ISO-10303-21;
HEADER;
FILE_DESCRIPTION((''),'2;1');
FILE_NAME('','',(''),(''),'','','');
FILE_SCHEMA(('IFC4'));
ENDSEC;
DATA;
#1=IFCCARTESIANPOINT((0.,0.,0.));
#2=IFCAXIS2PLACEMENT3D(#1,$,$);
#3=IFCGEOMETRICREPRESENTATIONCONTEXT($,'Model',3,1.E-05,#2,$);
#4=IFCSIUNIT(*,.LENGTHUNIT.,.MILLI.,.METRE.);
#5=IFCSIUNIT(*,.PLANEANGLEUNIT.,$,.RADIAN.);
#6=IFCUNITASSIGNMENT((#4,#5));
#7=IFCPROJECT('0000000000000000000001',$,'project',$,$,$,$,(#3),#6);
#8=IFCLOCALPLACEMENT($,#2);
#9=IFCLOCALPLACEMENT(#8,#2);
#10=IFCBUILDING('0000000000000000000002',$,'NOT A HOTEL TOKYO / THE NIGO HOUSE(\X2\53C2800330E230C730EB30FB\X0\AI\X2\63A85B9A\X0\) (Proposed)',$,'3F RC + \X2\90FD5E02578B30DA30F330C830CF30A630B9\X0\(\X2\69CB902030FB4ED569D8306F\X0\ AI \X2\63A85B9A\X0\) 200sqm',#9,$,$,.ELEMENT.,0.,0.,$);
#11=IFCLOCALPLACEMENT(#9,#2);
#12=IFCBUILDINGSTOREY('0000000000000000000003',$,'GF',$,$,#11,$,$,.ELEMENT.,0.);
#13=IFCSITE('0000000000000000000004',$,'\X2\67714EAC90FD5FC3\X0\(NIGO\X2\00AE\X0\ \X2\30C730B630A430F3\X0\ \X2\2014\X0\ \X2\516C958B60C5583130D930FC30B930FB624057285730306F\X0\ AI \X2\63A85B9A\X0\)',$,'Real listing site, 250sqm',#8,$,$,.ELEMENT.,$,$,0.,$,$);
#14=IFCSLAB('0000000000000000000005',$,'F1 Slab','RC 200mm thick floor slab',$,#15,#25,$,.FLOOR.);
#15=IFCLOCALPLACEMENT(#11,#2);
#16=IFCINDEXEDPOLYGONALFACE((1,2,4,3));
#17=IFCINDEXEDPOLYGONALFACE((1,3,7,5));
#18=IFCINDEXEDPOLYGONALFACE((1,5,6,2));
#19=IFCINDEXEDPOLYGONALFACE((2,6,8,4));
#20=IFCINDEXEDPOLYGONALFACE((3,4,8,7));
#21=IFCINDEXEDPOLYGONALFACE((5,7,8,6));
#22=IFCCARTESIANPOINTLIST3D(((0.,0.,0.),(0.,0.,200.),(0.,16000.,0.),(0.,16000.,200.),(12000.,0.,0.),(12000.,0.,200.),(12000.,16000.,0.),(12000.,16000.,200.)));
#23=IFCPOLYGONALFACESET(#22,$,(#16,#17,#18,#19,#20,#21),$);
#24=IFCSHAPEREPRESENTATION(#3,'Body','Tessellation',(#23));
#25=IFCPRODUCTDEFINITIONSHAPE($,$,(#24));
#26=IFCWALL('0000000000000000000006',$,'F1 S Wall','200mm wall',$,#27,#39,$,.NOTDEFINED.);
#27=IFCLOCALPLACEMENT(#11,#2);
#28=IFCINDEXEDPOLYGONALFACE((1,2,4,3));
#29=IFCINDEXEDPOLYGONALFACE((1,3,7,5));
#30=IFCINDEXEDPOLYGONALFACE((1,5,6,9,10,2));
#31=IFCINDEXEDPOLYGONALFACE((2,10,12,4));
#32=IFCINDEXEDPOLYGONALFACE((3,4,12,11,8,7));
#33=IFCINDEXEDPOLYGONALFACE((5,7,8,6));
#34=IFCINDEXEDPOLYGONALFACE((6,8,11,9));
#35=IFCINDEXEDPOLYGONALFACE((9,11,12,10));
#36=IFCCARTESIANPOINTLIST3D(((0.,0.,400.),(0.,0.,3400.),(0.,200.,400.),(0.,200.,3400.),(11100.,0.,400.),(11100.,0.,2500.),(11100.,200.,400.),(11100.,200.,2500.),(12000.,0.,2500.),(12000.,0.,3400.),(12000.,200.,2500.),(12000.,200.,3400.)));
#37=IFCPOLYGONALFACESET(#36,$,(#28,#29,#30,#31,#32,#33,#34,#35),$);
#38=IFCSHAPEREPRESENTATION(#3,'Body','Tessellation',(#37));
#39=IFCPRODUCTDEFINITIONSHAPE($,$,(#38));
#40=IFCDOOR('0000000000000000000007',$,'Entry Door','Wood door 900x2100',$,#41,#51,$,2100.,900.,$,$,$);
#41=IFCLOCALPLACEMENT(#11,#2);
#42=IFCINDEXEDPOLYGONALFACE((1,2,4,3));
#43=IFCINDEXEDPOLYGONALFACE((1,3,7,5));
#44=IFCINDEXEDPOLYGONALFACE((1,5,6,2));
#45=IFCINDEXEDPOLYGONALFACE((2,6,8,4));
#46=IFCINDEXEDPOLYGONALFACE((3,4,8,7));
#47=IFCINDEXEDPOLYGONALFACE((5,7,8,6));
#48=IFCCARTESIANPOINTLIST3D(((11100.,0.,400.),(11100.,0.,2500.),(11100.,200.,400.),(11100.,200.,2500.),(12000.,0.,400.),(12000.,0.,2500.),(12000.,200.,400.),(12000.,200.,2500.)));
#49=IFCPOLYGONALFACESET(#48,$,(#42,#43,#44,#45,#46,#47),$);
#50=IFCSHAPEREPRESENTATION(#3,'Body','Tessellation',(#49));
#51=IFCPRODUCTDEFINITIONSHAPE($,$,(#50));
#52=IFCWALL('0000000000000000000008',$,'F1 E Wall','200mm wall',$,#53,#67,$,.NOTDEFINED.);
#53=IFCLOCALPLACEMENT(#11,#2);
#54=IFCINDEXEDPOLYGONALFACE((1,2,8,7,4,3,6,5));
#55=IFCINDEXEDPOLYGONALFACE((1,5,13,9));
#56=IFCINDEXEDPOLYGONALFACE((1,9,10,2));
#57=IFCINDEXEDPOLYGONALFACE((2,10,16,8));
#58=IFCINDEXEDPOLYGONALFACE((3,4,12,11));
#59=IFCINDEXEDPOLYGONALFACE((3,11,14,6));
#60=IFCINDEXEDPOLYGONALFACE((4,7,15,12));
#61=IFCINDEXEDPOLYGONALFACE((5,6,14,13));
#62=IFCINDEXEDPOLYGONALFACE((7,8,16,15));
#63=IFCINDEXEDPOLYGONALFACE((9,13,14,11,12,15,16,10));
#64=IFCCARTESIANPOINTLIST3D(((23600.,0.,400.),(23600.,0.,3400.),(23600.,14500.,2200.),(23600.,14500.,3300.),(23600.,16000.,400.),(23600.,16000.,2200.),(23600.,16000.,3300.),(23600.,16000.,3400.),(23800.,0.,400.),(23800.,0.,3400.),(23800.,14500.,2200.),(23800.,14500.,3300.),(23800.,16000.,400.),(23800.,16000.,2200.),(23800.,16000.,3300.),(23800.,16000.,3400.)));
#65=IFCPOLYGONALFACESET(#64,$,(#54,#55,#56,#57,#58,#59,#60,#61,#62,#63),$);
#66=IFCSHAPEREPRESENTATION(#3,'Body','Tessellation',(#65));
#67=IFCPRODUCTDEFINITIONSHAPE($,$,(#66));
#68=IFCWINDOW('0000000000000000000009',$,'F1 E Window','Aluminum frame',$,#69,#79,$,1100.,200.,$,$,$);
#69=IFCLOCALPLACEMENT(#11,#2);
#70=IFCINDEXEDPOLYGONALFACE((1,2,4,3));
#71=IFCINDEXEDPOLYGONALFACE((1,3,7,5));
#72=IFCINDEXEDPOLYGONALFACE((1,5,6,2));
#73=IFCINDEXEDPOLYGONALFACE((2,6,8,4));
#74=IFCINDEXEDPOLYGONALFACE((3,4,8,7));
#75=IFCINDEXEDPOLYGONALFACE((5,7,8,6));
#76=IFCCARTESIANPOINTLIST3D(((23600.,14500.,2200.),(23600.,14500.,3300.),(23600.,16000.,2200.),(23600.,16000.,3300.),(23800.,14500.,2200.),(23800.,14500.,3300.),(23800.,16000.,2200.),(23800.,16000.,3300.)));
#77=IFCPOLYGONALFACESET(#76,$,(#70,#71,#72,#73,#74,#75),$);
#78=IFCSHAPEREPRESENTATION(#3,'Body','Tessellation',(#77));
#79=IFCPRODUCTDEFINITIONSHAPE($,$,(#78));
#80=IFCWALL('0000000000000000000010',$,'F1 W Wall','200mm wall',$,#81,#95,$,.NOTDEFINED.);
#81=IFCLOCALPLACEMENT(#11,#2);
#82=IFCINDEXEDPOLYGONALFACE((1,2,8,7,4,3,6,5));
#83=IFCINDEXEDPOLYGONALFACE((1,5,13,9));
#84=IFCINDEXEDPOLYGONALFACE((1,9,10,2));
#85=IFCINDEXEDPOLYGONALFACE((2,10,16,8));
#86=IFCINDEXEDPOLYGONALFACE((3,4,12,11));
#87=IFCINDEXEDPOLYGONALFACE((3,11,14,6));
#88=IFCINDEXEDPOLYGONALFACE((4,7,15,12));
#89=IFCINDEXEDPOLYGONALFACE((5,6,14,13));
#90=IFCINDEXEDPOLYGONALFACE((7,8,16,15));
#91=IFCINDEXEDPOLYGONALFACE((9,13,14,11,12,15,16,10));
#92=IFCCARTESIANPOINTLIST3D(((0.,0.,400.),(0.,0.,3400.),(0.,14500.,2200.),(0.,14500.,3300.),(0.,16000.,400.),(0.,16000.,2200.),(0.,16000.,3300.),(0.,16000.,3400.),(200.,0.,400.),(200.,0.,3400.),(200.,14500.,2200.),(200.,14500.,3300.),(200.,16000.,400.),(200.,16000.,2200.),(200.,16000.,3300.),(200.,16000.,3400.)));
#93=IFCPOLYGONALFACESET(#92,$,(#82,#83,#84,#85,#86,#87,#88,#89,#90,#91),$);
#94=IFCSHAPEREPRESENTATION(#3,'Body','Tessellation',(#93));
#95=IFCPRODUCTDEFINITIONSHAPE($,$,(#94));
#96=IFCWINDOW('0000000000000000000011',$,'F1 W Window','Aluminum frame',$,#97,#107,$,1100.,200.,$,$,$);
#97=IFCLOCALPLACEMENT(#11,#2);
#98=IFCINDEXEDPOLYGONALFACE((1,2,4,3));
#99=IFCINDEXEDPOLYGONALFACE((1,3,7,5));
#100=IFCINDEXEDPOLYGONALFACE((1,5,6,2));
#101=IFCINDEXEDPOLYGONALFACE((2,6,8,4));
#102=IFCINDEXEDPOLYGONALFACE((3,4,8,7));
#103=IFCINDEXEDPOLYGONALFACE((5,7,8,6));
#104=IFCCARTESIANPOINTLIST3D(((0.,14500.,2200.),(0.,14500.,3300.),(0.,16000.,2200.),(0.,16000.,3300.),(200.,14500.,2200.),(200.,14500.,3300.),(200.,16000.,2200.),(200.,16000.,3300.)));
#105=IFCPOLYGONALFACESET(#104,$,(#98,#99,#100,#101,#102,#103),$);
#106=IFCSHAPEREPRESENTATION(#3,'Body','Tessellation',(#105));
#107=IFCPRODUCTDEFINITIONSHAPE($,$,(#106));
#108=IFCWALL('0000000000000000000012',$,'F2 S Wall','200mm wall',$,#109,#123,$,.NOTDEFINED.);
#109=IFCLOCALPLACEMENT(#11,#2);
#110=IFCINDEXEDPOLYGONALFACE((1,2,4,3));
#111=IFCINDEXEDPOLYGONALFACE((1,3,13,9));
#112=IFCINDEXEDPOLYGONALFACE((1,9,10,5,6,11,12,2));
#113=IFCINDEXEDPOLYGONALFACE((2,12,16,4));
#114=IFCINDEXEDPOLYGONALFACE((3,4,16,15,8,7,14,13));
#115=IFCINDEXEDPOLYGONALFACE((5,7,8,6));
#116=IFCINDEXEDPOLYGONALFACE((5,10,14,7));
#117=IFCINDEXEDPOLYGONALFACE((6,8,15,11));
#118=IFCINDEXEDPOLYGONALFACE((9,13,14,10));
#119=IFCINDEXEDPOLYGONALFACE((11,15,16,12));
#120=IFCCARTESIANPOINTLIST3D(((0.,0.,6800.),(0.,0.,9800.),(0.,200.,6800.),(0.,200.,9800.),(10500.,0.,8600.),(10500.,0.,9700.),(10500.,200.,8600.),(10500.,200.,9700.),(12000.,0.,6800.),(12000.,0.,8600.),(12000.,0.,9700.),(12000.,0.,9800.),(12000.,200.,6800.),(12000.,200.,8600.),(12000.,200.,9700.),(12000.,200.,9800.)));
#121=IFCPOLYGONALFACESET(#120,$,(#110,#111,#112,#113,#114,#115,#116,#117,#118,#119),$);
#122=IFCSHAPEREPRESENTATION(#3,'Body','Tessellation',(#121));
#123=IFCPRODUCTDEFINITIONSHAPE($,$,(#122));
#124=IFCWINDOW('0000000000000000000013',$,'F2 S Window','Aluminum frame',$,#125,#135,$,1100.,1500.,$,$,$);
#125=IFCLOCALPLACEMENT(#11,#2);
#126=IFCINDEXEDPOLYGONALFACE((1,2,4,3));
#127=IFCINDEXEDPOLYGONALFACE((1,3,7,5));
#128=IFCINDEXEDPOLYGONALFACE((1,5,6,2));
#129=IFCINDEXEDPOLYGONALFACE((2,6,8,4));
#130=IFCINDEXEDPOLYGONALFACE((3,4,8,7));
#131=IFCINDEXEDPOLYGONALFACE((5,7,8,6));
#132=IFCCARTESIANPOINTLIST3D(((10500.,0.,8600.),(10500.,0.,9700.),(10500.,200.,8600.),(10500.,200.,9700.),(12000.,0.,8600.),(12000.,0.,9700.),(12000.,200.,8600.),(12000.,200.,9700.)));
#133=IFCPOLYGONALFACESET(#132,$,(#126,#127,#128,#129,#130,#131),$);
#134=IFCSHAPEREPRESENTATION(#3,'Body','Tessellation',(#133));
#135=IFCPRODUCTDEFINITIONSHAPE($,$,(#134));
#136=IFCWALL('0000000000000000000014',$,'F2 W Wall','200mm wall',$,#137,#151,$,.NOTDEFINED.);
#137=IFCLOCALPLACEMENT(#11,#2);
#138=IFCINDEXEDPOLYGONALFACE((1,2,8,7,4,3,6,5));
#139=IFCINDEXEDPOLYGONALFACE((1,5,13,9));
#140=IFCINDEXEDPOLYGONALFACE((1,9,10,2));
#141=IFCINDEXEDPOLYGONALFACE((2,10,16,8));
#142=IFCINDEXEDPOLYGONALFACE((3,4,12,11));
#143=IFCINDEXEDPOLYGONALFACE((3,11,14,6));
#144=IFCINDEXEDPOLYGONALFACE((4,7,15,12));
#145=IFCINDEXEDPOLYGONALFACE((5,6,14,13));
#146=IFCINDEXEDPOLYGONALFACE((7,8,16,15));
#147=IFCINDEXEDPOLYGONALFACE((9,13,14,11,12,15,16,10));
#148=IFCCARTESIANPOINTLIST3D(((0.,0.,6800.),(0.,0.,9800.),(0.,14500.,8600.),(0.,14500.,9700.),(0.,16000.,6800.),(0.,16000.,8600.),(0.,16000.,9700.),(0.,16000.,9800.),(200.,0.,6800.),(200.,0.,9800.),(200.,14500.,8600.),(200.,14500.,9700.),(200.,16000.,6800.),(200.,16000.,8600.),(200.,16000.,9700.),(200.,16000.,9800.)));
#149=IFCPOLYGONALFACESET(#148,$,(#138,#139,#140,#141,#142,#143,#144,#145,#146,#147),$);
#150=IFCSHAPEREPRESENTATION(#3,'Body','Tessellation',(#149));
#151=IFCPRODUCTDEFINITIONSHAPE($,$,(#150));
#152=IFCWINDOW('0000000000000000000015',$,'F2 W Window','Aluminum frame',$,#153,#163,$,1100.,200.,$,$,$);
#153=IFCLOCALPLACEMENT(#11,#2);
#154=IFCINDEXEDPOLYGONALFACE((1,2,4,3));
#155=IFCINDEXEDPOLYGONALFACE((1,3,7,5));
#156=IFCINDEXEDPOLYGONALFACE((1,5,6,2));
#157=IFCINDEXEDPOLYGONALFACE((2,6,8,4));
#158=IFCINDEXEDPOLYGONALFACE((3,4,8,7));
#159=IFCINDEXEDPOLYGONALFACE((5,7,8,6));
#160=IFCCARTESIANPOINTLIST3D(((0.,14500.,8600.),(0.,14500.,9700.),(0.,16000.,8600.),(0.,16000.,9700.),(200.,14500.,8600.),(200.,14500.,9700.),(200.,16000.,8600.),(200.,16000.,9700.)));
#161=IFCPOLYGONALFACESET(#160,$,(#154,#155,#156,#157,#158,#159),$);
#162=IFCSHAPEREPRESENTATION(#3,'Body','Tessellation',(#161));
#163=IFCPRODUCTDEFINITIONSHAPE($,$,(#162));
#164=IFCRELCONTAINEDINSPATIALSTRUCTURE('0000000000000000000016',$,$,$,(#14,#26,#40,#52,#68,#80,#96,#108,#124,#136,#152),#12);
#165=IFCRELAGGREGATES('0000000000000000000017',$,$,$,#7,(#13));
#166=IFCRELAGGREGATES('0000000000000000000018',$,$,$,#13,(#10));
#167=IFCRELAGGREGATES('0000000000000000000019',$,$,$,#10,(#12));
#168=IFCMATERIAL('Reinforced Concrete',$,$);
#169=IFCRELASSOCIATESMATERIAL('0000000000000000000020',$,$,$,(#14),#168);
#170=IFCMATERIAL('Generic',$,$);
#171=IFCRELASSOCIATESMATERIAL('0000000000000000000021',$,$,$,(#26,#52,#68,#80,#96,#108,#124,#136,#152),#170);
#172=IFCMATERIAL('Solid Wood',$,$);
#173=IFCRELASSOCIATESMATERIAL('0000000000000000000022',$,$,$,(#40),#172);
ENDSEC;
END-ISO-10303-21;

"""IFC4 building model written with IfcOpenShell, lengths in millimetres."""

from ifc_helpers import new_model, si_unit, frame, frame_2d, origin, place, context, project, spatial, rectangle, extrude, material, element, fill, save


model = new_model("IFC4")

# Units and contexts
model_context = context("Model", 3, precision=1e-05, world=origin())
ifc_project = project(units=[si_unit("LENGTHUNIT", "METRE", prefix="MILLI"), si_unit("PLANEANGLEUNIT", "RADIAN")], contexts=[model_context])

# Site, building, storey
site_placement = place(None, origin())
site = spatial("IfcSite", under=ifc_project, at=site_placement, Name="東京都心(NIGO® デザイン — 公開情報ベース・所在地は AI 推定)", ObjectType="Real listing site, 250sqm", CompositionType="ELEMENT", RefElevation=0.0)
building_placement = place(site_placement, origin())
building = spatial("IfcBuilding", under=site, at=building_placement, Name="NOT A HOTEL TOKYO / THE NIGO HOUSE(参考モデル・AI推定) (Proposed)", ObjectType="3F RC + 都市型ペントハウス(構造・仕様は AI 推定) 200sqm", CompositionType="ELEMENT", ElevationOfRefHeight=0.0, ElevationOfTerrain=0.0)
storey_placement = place(building_placement, origin())
storey = spatial("IfcBuildingStorey", under=building, at=storey_placement, Name="GF", CompositionType="ELEMENT", Elevation=0.0)

# Slab
ifc_material_1 = material(Name="Reinforced Concrete")
slab_1_placement = place(storey_placement, origin())
element("IfcSlab", 1, at=slab_1_placement, inside=storey, material=ifc_material_1, Name="F1 Slab", Description="RC 200mm thick floor slab", PredefinedType="FLOOR", context=model_context, shape_type="SweptSolid", body=[
    extrude(rectangle(XDim=12000.0, YDim=16000.0, at=frame_2d((6000.0, 8000.0))), origin(), (0.0, 0.0, 1.0), 200.0),
])

# Wall, opening, door
ifc_material_2 = material(Name="Generic")
wall_1_placement = place(storey_placement, frame((0.0, 0.0, 200.0)))
wall_1 = element("IfcWall", 2, at=wall_1_placement, inside=storey, material=ifc_material_2, Name="F1 S Wall", Description="200mm wall", PredefinedType="NOTDEFINED", context=model_context, shape_type="SweptSolid", body=[
    extrude(rectangle(XDim=12000.0, YDim=200.0, at=frame_2d((6000.0, 100.0))), frame((0.0, 0.0, 200.0)), (0.0, 0.0, 1.0), 3000.0),
])
opening_1_placement = place(storey_placement, frame((5550.0, 0.0, 200.0)))
opening_1 = element("IfcOpeningElement", 3, at=opening_1_placement, cuts=wall_1, PredefinedType="NOTDEFINED", context=model_context, shape_type="SweptSolid", body=[
    extrude(rectangle(XDim=900.0, YDim=200.0, at=frame_2d((450.0, 100.0))), frame((5550.0, 0.0, 200.0)), (0.0, 0.0, 1.0), 2100.0),
])
ifc_material_3 = material(Name="Solid Wood")
door_placement = place(storey_placement, frame((5550.0, 0.0, 200.0)))
door = element("IfcDoor", 4, at=door_placement, inside=storey, material=ifc_material_3, Name="Entry Door", Description="Wood door 900x2100", OverallHeight=2100.0, OverallWidth=900.0, context=model_context, shape_type="SweptSolid", body=[
    extrude(rectangle(XDim=900.0, YDim=200.0, at=frame_2d((450.0, 100.0))), frame((5550.0, 0.0, 200.0)), (0.0, 0.0, 1.0), 2100.0),
])
fill(opening_1, door)

# Walls, openings, windows
wall_2_placement = place(storey_placement, frame((11800.0, 0.0, 200.0)))
wall_2 = element("IfcWall", 5, at=wall_2_placement, inside=storey, material=ifc_material_2, Name="F1 E Wall", Description="200mm wall", PredefinedType="NOTDEFINED", context=model_context, shape_type="SweptSolid", body=[
    extrude(rectangle(XDim=200.0, YDim=16000.0, at=frame_2d((100.0, 8000.0))), frame((11800.0, 0.0, 200.0)), (0.0, 0.0, 1.0), 3000.0),
])
opening_2_placement = place(storey_placement, frame((11800.0, 7250.0, 1100.0)))
opening_2 = element("IfcOpeningElement", 6, at=opening_2_placement, cuts=wall_2, PredefinedType="NOTDEFINED", context=model_context, shape_type="SweptSolid", body=[
    extrude(rectangle(XDim=200.0, YDim=1500.0, at=frame_2d((100.0, 750.0))), frame((11800.0, 7250.0, 1100.0)), (0.0, 0.0, 1.0), 1100.0),
])
window_1_placement = place(storey_placement, frame((11800.0, 7250.0, 1100.0)))
window_1 = element("IfcWindow", 7, at=window_1_placement, inside=storey, material=ifc_material_2, Name="F1 E Window", Description="Aluminum frame", OverallHeight=1100.0, OverallWidth=200.0, context=model_context, shape_type="SweptSolid", body=[
    extrude(rectangle(XDim=200.0, YDim=1500.0, at=frame_2d((100.0, 750.0))), frame((11800.0, 7250.0, 1100.0)), (0.0, 0.0, 1.0), 1100.0),
])
fill(opening_2, window_1)
wall_3_placement = place(storey_placement, frame((0.0, 0.0, 200.0)))
wall_3 = element("IfcWall", 8, at=wall_3_placement, inside=storey, material=ifc_material_2, Name="F1 W Wall", Description="200mm wall", PredefinedType="NOTDEFINED", context=model_context, shape_type="SweptSolid", body=[
    extrude(rectangle(XDim=200.0, YDim=16000.0, at=frame_2d((100.0, 8000.0))), frame((0.0, 0.0, 200.0)), (0.0, 0.0, 1.0), 3000.0),
])
opening_3_placement = place(storey_placement, frame((0.0, 7250.0, 1100.0)))
opening_3 = element("IfcOpeningElement", 9, at=opening_3_placement, cuts=wall_3, PredefinedType="NOTDEFINED", context=model_context, shape_type="SweptSolid", body=[
    extrude(rectangle(XDim=200.0, YDim=1500.0, at=frame_2d((100.0, 750.0))), frame((0.0, 7250.0, 1100.0)), (0.0, 0.0, 1.0), 1100.0),
])
window_2_placement = place(storey_placement, frame((0.0, 7250.0, 1100.0)))
window_2 = element("IfcWindow", 10, at=window_2_placement, inside=storey, material=ifc_material_2, Name="F1 W Window", Description="Aluminum frame", OverallHeight=1100.0, OverallWidth=200.0, context=model_context, shape_type="SweptSolid", body=[
    extrude(rectangle(XDim=200.0, YDim=1500.0, at=frame_2d((100.0, 750.0))), frame((0.0, 7250.0, 1100.0)), (0.0, 0.0, 1.0), 1100.0),
])
fill(opening_3, window_2)
wall_4_placement = place(storey_placement, frame((0.0, 0.0, 3400.0)))
wall_4 = element("IfcWall", 11, at=wall_4_placement, inside=storey, material=ifc_material_2, Name="F2 S Wall", Description="200mm wall", PredefinedType="NOTDEFINED", context=model_context, shape_type="SweptSolid", body=[
    extrude(rectangle(XDim=12000.0, YDim=200.0, at=frame_2d((6000.0, 100.0))), frame((0.0, 0.0, 3400.0)), (0.0, 0.0, 1.0), 3000.0),
])
opening_4_placement = place(storey_placement, frame((5250.0, 0.0, 4300.0)))
opening_4 = element("IfcOpeningElement", 12, at=opening_4_placement, cuts=wall_4, PredefinedType="NOTDEFINED", context=model_context, shape_type="SweptSolid", body=[
    extrude(rectangle(XDim=1500.0, YDim=200.0, at=frame_2d((750.0, 100.0))), frame((5250.0, 0.0, 4300.0)), (0.0, 0.0, 1.0), 1100.0),
])
window_3_placement = place(storey_placement, frame((5250.0, 0.0, 4300.0)))
window_3 = element("IfcWindow", 13, at=window_3_placement, inside=storey, material=ifc_material_2, Name="F2 S Window", Description="Aluminum frame", OverallHeight=1100.0, OverallWidth=1500.0, context=model_context, shape_type="SweptSolid", body=[
    extrude(rectangle(XDim=1500.0, YDim=200.0, at=frame_2d((750.0, 100.0))), frame((5250.0, 0.0, 4300.0)), (0.0, 0.0, 1.0), 1100.0),
])
fill(opening_4, window_3)
wall_5_placement = place(storey_placement, frame((0.0, 0.0, 3400.0)))
wall_5 = element("IfcWall", 14, at=wall_5_placement, inside=storey, material=ifc_material_2, Name="F2 W Wall", Description="200mm wall", PredefinedType="NOTDEFINED", context=model_context, shape_type="SweptSolid", body=[
    extrude(rectangle(XDim=200.0, YDim=16000.0, at=frame_2d((100.0, 8000.0))), frame((0.0, 0.0, 3400.0)), (0.0, 0.0, 1.0), 3000.0),
])
opening_5_placement = place(storey_placement, frame((0.0, 7250.0, 4300.0)))
opening_5 = element("IfcOpeningElement", 15, at=opening_5_placement, cuts=wall_5, PredefinedType="NOTDEFINED", context=model_context, shape_type="SweptSolid", body=[
    extrude(rectangle(XDim=200.0, YDim=1500.0, at=frame_2d((100.0, 750.0))), frame((0.0, 7250.0, 4300.0)), (0.0, 0.0, 1.0), 1100.0),
])
window_4_placement = place(storey_placement, frame((0.0, 7250.0, 4300.0)))
window_4 = element("IfcWindow", 16, at=window_4_placement, inside=storey, material=ifc_material_2, Name="F2 W Window", Description="Aluminum frame", OverallHeight=1100.0, OverallWidth=200.0, context=model_context, shape_type="SweptSolid", body=[
    extrude(rectangle(XDim=200.0, YDim=1500.0, at=frame_2d((100.0, 750.0))), frame((0.0, 7250.0, 4300.0)), (0.0, 0.0, 1.0), 1100.0),
])
fill(opening_5, window_4)

save(model, "model.ifc")
